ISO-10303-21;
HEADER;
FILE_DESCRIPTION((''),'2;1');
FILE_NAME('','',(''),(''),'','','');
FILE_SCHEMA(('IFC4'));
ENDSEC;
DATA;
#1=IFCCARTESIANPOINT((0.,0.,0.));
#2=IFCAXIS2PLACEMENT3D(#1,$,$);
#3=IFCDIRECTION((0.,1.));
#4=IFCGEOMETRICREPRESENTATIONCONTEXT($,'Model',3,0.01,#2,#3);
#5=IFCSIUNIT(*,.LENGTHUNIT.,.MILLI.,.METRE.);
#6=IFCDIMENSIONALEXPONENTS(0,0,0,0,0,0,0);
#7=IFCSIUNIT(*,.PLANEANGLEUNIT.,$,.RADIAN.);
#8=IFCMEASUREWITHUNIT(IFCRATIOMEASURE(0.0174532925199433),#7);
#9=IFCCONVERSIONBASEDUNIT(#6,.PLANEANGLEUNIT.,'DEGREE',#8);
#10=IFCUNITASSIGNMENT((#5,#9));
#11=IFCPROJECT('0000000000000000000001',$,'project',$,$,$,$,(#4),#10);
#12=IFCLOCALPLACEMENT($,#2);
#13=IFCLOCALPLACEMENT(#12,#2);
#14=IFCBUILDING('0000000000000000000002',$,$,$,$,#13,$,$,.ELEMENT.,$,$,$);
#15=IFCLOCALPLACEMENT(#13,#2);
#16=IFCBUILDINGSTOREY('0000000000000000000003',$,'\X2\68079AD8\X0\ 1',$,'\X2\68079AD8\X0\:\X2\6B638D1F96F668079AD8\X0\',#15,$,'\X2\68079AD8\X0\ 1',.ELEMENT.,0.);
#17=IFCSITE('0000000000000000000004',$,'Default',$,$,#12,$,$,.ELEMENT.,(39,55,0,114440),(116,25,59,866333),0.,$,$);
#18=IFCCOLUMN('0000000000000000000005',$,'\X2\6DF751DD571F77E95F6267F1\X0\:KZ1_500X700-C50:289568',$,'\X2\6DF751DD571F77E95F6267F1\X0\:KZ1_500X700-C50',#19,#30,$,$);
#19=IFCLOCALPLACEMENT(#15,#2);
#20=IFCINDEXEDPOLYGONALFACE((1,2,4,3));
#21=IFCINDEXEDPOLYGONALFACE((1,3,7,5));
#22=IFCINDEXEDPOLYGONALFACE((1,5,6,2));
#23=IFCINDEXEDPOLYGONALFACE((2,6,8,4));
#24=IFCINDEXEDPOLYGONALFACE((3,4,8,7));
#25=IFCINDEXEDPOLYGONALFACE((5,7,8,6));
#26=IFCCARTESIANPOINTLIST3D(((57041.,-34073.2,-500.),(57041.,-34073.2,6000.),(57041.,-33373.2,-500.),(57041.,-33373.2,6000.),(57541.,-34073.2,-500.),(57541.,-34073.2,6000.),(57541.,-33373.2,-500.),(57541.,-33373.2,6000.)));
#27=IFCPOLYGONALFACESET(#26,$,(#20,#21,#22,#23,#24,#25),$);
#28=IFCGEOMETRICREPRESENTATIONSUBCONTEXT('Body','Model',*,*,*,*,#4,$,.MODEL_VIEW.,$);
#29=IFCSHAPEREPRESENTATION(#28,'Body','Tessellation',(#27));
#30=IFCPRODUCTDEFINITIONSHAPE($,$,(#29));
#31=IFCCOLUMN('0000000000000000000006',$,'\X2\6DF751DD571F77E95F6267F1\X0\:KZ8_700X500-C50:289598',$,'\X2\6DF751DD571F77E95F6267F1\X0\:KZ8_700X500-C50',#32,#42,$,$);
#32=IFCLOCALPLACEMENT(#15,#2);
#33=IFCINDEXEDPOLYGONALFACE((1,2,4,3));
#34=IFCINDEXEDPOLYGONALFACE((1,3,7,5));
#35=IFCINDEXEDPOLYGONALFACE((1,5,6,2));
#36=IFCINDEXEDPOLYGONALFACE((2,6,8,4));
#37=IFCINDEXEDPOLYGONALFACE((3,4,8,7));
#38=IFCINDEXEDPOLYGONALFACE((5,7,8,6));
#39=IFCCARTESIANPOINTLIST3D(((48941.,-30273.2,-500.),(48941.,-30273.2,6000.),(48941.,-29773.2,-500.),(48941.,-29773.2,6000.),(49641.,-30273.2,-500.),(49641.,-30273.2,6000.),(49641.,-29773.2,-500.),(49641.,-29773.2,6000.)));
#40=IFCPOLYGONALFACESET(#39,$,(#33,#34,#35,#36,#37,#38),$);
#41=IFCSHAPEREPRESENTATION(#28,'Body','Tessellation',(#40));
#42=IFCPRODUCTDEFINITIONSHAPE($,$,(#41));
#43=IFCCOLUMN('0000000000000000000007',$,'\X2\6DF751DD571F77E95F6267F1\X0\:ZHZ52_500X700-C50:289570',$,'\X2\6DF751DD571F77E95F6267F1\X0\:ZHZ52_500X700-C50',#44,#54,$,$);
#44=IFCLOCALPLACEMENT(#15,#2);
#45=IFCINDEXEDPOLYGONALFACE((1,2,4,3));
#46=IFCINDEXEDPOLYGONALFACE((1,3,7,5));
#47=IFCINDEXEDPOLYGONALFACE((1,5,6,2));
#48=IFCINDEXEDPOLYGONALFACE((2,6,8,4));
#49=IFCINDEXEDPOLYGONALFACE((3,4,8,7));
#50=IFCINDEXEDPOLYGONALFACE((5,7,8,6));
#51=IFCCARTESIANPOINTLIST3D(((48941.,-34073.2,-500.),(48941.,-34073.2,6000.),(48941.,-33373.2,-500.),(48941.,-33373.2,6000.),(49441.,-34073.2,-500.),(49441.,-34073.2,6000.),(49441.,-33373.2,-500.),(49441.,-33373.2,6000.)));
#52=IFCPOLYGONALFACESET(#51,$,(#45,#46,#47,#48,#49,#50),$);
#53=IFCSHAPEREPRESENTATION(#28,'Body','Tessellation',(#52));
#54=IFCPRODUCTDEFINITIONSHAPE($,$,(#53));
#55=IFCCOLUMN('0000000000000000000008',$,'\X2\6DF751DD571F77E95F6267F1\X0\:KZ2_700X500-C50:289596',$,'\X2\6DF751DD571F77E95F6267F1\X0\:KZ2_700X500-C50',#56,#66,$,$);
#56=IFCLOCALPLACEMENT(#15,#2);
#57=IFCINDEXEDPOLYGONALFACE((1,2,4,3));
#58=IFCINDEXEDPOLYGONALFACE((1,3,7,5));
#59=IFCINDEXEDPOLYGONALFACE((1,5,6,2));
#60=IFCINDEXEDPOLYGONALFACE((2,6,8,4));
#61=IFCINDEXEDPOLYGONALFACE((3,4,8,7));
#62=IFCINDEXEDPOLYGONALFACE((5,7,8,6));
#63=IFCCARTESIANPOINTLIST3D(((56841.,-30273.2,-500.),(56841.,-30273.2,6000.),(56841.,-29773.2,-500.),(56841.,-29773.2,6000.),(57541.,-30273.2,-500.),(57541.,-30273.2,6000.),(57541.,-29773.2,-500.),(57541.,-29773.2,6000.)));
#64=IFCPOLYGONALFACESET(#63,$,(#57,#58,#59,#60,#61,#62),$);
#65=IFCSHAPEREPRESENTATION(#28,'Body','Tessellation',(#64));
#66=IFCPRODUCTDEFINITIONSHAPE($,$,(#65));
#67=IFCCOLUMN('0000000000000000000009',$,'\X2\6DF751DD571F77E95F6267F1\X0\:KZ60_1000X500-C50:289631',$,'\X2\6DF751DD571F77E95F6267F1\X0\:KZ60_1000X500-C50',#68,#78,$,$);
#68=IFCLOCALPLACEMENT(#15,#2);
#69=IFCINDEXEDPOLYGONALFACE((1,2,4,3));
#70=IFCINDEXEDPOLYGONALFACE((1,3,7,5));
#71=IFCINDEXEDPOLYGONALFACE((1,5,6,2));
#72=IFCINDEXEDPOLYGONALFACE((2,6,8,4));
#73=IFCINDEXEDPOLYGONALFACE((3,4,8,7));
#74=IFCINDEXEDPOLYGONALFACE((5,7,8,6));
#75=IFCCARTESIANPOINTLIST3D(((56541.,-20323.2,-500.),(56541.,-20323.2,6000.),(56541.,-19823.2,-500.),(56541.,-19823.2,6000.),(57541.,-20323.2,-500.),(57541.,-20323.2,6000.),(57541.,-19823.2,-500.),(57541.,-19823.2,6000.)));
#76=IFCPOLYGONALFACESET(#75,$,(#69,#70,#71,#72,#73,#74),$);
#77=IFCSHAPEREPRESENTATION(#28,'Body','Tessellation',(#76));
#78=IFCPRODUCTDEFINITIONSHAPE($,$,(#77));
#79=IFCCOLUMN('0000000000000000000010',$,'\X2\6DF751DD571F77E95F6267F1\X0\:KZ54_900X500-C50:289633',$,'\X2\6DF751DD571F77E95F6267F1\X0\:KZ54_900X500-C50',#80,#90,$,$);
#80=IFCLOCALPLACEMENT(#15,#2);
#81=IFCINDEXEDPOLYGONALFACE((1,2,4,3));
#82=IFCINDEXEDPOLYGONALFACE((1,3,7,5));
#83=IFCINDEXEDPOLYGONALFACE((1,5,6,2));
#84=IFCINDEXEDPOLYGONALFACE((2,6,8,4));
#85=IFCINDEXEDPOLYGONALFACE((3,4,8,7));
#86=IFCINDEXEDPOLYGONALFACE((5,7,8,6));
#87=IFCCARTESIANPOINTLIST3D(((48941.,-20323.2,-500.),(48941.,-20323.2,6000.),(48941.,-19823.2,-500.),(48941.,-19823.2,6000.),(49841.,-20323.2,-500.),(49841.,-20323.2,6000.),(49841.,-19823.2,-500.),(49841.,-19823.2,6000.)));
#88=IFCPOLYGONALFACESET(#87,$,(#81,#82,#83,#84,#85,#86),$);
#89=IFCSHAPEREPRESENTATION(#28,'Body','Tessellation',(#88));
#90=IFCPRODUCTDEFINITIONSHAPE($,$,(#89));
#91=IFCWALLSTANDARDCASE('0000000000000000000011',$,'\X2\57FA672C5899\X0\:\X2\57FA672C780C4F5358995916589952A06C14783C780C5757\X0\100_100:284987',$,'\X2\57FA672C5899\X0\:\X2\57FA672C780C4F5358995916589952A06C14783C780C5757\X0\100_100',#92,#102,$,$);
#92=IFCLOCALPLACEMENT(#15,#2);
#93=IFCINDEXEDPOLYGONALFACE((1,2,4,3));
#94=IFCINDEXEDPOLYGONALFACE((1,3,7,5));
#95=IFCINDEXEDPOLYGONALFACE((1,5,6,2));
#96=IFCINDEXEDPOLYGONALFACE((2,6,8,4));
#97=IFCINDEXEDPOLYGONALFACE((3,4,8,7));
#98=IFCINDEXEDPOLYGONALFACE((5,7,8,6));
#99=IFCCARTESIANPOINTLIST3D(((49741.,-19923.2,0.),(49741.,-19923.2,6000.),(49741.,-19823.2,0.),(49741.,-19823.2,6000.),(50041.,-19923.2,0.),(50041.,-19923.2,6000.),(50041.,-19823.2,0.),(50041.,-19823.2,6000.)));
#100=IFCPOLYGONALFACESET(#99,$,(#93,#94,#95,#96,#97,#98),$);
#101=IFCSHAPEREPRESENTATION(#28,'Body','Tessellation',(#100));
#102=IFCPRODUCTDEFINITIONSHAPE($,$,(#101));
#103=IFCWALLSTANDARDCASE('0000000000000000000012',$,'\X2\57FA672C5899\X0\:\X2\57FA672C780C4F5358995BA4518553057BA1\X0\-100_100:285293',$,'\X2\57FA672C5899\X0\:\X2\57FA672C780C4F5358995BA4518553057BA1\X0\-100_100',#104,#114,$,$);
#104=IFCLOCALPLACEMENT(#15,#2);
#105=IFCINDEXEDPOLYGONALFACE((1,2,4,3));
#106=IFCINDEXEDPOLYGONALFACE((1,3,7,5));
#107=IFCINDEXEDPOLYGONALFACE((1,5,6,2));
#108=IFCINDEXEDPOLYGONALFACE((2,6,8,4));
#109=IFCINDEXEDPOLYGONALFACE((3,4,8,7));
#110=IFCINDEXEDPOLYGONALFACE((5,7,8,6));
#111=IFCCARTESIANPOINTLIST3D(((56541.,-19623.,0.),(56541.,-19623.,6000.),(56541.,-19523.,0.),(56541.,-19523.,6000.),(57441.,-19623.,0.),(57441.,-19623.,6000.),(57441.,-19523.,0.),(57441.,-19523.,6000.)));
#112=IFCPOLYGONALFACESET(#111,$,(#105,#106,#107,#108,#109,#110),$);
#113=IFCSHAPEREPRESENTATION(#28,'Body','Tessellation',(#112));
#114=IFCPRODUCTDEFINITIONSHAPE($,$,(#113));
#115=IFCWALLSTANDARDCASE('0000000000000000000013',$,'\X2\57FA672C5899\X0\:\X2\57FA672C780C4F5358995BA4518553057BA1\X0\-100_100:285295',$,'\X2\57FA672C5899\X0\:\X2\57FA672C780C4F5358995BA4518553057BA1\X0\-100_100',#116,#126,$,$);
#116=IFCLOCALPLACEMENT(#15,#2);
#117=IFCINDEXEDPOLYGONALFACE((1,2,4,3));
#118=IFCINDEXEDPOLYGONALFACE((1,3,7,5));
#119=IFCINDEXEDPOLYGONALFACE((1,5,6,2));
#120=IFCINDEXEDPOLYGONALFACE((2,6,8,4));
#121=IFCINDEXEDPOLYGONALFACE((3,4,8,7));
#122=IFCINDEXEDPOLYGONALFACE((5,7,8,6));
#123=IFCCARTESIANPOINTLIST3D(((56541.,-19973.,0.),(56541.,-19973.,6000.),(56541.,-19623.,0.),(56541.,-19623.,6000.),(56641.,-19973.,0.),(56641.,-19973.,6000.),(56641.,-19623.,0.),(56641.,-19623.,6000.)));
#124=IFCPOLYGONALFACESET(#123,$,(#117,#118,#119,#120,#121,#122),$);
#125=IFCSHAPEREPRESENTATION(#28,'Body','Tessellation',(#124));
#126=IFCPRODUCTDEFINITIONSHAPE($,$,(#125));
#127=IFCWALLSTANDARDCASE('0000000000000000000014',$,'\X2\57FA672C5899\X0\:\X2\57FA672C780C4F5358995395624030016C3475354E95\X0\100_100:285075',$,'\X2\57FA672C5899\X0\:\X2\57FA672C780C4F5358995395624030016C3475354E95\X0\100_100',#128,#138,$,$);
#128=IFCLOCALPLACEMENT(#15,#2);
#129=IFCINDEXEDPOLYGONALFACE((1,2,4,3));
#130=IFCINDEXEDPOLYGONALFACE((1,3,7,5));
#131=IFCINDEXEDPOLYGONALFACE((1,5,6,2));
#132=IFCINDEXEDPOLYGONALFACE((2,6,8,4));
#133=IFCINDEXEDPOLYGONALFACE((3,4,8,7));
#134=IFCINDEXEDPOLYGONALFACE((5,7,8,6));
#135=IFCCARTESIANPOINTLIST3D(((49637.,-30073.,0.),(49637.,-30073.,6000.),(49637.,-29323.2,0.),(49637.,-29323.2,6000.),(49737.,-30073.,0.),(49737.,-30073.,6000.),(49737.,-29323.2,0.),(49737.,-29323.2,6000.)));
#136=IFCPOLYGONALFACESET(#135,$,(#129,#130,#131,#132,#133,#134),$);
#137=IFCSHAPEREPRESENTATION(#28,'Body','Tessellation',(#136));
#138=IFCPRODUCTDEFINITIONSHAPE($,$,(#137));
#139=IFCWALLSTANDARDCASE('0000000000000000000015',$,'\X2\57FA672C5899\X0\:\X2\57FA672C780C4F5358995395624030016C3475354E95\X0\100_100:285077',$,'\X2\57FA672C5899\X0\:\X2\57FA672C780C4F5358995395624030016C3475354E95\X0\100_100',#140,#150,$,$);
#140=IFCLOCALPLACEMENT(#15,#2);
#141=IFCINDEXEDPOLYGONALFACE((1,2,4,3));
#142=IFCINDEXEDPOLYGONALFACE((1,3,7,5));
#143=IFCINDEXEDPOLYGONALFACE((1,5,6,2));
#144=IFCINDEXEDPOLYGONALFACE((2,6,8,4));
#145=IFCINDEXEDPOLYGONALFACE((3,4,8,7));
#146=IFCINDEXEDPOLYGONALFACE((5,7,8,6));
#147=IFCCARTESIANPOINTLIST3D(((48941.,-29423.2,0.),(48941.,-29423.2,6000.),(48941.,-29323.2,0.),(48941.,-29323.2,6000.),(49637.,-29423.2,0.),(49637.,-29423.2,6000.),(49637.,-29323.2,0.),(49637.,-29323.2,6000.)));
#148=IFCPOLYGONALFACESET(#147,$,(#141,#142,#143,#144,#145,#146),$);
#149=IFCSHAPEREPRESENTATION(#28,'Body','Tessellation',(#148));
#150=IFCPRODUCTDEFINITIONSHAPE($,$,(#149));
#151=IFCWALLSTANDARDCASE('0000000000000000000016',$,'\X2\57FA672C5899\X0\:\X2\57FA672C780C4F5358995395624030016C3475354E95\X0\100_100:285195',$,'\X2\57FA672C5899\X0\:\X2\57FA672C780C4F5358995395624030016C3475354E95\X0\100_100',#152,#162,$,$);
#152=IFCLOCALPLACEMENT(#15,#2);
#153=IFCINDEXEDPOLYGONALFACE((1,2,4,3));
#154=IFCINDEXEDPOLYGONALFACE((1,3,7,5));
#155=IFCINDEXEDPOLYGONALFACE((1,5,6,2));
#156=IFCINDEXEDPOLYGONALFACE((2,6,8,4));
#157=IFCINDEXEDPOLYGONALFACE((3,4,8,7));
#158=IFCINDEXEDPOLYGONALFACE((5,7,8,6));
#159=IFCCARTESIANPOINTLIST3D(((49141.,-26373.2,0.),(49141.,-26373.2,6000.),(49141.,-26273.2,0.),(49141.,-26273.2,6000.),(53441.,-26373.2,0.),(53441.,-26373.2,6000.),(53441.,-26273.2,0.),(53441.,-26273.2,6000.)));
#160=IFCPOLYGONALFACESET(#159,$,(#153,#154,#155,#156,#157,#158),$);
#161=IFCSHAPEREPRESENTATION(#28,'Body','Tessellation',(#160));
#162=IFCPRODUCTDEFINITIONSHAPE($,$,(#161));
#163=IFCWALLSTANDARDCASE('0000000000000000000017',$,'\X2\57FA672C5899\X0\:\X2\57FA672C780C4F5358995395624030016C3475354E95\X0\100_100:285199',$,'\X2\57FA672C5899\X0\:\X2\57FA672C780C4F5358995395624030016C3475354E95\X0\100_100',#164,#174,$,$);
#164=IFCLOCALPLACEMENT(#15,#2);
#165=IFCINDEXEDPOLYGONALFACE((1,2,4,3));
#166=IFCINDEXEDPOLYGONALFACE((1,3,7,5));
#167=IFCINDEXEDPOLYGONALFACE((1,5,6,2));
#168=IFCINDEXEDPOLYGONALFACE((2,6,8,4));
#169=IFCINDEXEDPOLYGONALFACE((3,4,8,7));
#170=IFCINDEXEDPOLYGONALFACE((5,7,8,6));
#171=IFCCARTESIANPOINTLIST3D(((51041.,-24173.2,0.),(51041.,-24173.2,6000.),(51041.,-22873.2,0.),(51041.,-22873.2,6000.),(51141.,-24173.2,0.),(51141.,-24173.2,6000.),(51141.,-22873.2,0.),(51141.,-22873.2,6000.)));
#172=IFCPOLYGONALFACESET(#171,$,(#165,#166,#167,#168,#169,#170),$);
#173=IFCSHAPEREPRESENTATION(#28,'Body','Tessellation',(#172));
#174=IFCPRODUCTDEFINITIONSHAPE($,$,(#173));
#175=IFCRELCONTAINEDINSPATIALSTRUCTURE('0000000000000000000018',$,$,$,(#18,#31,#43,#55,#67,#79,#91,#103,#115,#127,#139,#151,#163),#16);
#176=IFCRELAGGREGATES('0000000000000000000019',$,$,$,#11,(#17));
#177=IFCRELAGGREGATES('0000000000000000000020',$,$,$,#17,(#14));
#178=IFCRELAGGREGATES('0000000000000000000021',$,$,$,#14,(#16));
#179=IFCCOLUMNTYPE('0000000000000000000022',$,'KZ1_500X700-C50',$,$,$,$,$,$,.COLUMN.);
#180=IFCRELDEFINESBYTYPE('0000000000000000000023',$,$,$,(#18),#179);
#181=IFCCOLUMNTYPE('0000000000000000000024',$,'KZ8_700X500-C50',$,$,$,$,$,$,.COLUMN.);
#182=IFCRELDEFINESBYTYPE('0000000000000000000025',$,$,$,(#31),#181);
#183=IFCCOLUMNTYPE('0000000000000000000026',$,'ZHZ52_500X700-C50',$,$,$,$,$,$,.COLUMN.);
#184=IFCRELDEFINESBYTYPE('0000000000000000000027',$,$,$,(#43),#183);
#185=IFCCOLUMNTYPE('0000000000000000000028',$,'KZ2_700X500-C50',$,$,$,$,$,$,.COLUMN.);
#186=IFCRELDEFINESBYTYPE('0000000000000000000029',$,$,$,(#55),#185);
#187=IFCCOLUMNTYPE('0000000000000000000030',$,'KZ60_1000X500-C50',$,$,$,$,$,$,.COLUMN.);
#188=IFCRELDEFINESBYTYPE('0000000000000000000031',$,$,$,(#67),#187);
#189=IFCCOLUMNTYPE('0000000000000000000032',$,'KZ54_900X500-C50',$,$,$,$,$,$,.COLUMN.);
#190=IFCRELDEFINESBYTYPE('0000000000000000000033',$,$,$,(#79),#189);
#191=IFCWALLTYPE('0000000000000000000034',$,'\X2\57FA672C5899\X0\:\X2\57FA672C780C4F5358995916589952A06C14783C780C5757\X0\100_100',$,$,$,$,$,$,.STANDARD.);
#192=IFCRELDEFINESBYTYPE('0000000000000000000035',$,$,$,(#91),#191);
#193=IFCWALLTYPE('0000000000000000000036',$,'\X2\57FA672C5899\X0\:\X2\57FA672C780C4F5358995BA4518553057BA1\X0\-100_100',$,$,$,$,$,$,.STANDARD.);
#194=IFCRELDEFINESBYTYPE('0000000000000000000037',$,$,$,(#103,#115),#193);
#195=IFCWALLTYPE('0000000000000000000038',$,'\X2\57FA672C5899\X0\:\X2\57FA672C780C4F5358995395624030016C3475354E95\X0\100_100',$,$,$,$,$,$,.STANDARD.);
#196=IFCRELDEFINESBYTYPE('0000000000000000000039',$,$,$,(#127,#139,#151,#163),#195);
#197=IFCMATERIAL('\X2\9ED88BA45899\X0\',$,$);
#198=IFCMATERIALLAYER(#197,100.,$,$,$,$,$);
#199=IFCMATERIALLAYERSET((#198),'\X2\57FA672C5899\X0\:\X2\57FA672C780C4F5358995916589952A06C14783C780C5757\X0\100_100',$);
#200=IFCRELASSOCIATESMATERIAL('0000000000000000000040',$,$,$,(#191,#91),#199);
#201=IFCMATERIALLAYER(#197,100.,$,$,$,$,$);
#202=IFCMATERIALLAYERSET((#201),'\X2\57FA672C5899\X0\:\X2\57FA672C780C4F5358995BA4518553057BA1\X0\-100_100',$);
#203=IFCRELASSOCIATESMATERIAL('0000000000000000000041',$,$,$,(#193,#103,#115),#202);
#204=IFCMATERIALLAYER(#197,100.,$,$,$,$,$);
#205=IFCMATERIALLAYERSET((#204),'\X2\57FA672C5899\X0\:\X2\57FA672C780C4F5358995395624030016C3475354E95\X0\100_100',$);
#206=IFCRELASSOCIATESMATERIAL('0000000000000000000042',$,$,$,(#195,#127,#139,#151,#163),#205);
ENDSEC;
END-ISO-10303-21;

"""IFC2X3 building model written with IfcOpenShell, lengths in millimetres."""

from ifc_helpers import new_model, entity, si_unit, converted_unit, direction, frame, frame_2d, origin, origin_2d_with_axis, place, context, subcontext, project, spatial, rectangle, extrude, source, transform, mapped, material, layer, layer_set, layer_usage, type_object, type_shapes, element, save


model = new_model("IFC2X3")

# Units and contexts
model_context = context("Model", 3, precision=0.01, world=origin(), true_north=direction((0.0, 1.0)))
body_context = subcontext(model_context, "Body", "Model", "MODEL_VIEW")
ifc_project = project(units=[si_unit("LENGTHUNIT", "METRE", prefix="MILLI"), converted_unit("PLANEANGLEUNIT", "DEGREE", entity("IfcRatioMeasure", 0.0174532925199433), si_unit("PLANEANGLEUNIT", "RADIAN"), dimensions=[0, 0, 0, 0, 0, 0, 0])], contexts=[model_context])

# Site, building, storey
site_placement = place(None, origin())
site = spatial("IfcSite", under=ifc_project, at=site_placement, Name="Default", CompositionType="ELEMENT", RefLatitude=(39, 55, 0, 114440), RefLongitude=(116, 25, 59, 866333), RefElevation=0.0)
building_placement = place(site_placement, origin())
building = spatial("IfcBuilding", under=site, at=building_placement, CompositionType="ELEMENT")
storey_placement = place(building_placement, origin())
storey = spatial("IfcBuildingStorey", under=building, at=storey_placement, Name="标高 1", ObjectType="标高:正负零标高", LongName="标高 1", CompositionType="ELEMENT", Elevation=0.0)

# Columns
column_type_1 = type_object("IfcColumnType", Name="KZ1_500X700-C50", PredefinedType="COLUMN")
shared_shape_1 = source(origin(), body_context, "Body", "SweptSolid", [
    extrude(rectangle(XDim=700.0, YDim=500.0, at=origin_2d_with_axis()), frame((0.0, 0.0, -500.0), z_axis=(0.0, 0.0, 1.0), x_axis=(0.0, -1.0, 0.0)), (0.0, 0.0, 1.0), 6500.0),
])
type_shapes(column_type_1, [shared_shape_1])
column_1_placement = place(building_placement, frame((57291.0, -33723.2, 0.0)))
element("IfcColumn", 1, at=column_1_placement, inside=storey, type_object=column_type_1, Name="混凝土矩形柱:KZ1_500X700-C50:289568", ObjectType="混凝土矩形柱:KZ1_500X700-C50", context=body_context, shape_type="MappedRepresentation", body=[
    mapped(shared_shape_1, transform((0.0, 0.0, 0.0), scale=1.0)),
])
column_type_2 = type_object("IfcColumnType", Name="KZ8_700X500-C50", PredefinedType="COLUMN")
shared_shape_2 = source(origin(), body_context, "Body", "SweptSolid", [
    extrude(rectangle(XDim=500.0, YDim=700.0, at=origin_2d_with_axis()), frame((0.0, 0.0, -500.0), z_axis=(0.0, 0.0, 1.0), x_axis=(0.0, -1.0, 0.0)), (0.0, 0.0, 1.0), 6500.0),
])
type_shapes(column_type_2, [shared_shape_2])
column_2_placement = place(building_placement, frame((49291.0, -30023.2, 0.0)))
element("IfcColumn", 2, at=column_2_placement, inside=storey, type_object=column_type_2, Name="混凝土矩形柱:KZ8_700X500-C50:289598", ObjectType="混凝土矩形柱:KZ8_700X500-C50", context=body_context, shape_type="MappedRepresentation", body=[
    mapped(shared_shape_2, transform((0.0, 0.0, 0.0), scale=1.0)),
])
column_type_3 = type_object("IfcColumnType", Name="ZHZ52_500X700-C50", PredefinedType="COLUMN")
shared_shape_3 = source(origin(), body_context, "Body", "SweptSolid", [
    extrude(rectangle(XDim=700.0, YDim=500.0, at=origin_2d_with_axis()), frame((0.0, 0.0, -500.0), z_axis=(0.0, 0.0, 1.0), x_axis=(0.0, -1.0, 0.0)), (0.0, 0.0, 1.0), 6500.0),
])
type_shapes(column_type_3, [shared_shape_3])
column_3_placement = place(building_placement, frame((49191.0, -33723.2, 0.0)))
element("IfcColumn", 3, at=column_3_placement, inside=storey, type_object=column_type_3, Name="混凝土矩形柱:ZHZ52_500X700-C50:289570", ObjectType="混凝土矩形柱:ZHZ52_500X700-C50", context=body_context, shape_type="MappedRepresentation", body=[
    mapped(shared_shape_3, transform((0.0, 0.0, 0.0), scale=1.0)),
])
column_type_4 = type_object("IfcColumnType", Name="KZ2_700X500-C50", PredefinedType="COLUMN")
shared_shape_4 = source(origin(), body_context, "Body", "SweptSolid", [
    extrude(rectangle(XDim=500.0, YDim=700.0, at=origin_2d_with_axis()), frame((0.0, 0.0, -500.0), z_axis=(0.0, 0.0, 1.0), x_axis=(0.0, -1.0, 0.0)), (0.0, 0.0, 1.0), 6500.0),
])
type_shapes(column_type_4, [shared_shape_4])
column_4_placement = place(building_placement, frame((57191.0, -30023.2, 0.0)))
element("IfcColumn", 4, at=column_4_placement, inside=storey, type_object=column_type_4, Name="混凝土矩形柱:KZ2_700X500-C50:289596", ObjectType="混凝土矩形柱:KZ2_700X500-C50", context=body_context, shape_type="MappedRepresentation", body=[
    mapped(shared_shape_4, transform((0.0, 0.0, 0.0), scale=1.0)),
])
column_type_5 = type_object("IfcColumnType", Name="KZ60_1000X500-C50", PredefinedType="COLUMN")
shared_shape_5 = source(origin(), body_context, "Body", "SweptSolid", [
    extrude(rectangle(XDim=500.0, YDim=1000.0, at=origin_2d_with_axis()), frame((0.0, 0.0, -500.0), z_axis=(0.0, 0.0, 1.0), x_axis=(0.0, -1.0, 0.0)), (0.0, 0.0, 1.0), 6500.0),
])
type_shapes(column_type_5, [shared_shape_5])
column_5_placement = place(building_placement, frame((57041.0, -20073.2, 0.0)))
element("IfcColumn", 5, at=column_5_placement, inside=storey, type_object=column_type_5, Name="混凝土矩形柱:KZ60_1000X500-C50:289631", ObjectType="混凝土矩形柱:KZ60_1000X500-C50", context=body_context, shape_type="MappedRepresentation", body=[
    mapped(shared_shape_5, transform((0.0, 0.0, 0.0), scale=1.0)),
])
column_type_6 = type_object("IfcColumnType", Name="KZ54_900X500-C50", PredefinedType="COLUMN")
shared_shape_6 = source(origin(), body_context, "Body", "SweptSolid", [
    extrude(rectangle(XDim=500.0, YDim=900.0, at=origin_2d_with_axis()), frame((0.0, 0.0, -500.0), z_axis=(0.0, 0.0, 1.0), x_axis=(0.0, -1.0, 0.0)), (0.0, 0.0, 1.0), 6500.0),
])
type_shapes(column_type_6, [shared_shape_6])
column_6_placement = place(building_placement, frame((49391.0, -20073.2, 0.0)))
element("IfcColumn", 6, at=column_6_placement, inside=storey, type_object=column_type_6, Name="混凝土矩形柱:KZ54_900X500-C50:289633", ObjectType="混凝土矩形柱:KZ54_900X500-C50", context=body_context, shape_type="MappedRepresentation", body=[
    mapped(shared_shape_6, transform((0.0, 0.0, 0.0), scale=1.0)),
])

# Walls
ifc_material = material(Name="默认墙")
ifc_layer_1 = layer(ifc_material, 100.0)
ifc_layer_set_1 = layer_set([ifc_layer_1], Name="基本墙:基本砌体墙外墙加气砼砌块100_100")
ifc_layer_usage_1 = layer_usage(ifc_layer_set_1, "AXIS2", "NEGATIVE", 50.0)
wall_type_1 = type_object("IfcWallType", Name="基本墙:基本砌体墙外墙加气砼砌块100_100", PredefinedType="STANDARD", material=ifc_layer_set_1)
wall_1_placement = place(building_placement, frame((49741.0, -19873.2, 0.0)))
element("IfcWallStandardCase", 7, at=wall_1_placement, inside=storey, type_object=wall_type_1, material=ifc_layer_usage_1, Name="基本墙:基本砌体墙外墙加气砼砌块100_100:284987", ObjectType="基本墙:基本砌体墙外墙加气砼砌块100_100", context=body_context, shape_type="SweptSolid", body=[
    extrude(rectangle(XDim=300.0, YDim=100.0, at=frame_2d((150.0, 0.0), x_axis=(-1.0, 0.0))), origin(), (0.0, 0.0, 1.0), 6000.0),
])
ifc_layer_2 = layer(ifc_material, 100.0)
ifc_layer_set_2 = layer_set([ifc_layer_2], Name="基本墙:基本砌体墙室内包管-100_100")
ifc_layer_usage_2 = layer_usage(ifc_layer_set_2, "AXIS2", "NEGATIVE", 50.0)
wall_type_2 = type_object("IfcWallType", Name="基本墙:基本砌体墙室内包管-100_100", PredefinedType="STANDARD", material=ifc_layer_set_2)
wall_2_placement = place(building_placement, frame((57441.0, -19573.0, 0.0), z_axis=(0.0, 0.0, 1.0), x_axis=(-1.0, 0.0, 0.0)))
element("IfcWallStandardCase", 8, at=wall_2_placement, inside=storey, type_object=wall_type_2, material=ifc_layer_usage_2, Name="基本墙:基本砌体墙室内包管-100_100:285293", ObjectType="基本墙:基本砌体墙室内包管-100_100", context=body_context, shape_type="SweptSolid", body=[
    extrude(rectangle(XDim=900.0, YDim=100.0, at=frame_2d((450.0, 0.0), x_axis=(-1.0, 0.0))), origin(), (0.0, 0.0, 1.0), 6000.0),
])
ifc_layer_usage_3 = layer_usage(ifc_layer_set_2, "AXIS2", "NEGATIVE", 50.0)
wall_3_placement = place(building_placement, frame((56591.0, -19623.0, 0.0), z_axis=(0.0, 0.0, 1.0), x_axis=(0.0, -1.0, 0.0)))
element("IfcWallStandardCase", 9, at=wall_3_placement, inside=storey, type_object=wall_type_2, material=ifc_layer_usage_3, Name="基本墙:基本砌体墙室内包管-100_100:285295", ObjectType="基本墙:基本砌体墙室内包管-100_100", context=body_context, shape_type="SweptSolid", body=[
    extrude(rectangle(XDim=350.0, YDim=100.0, at=frame_2d((175.0, 0.0), x_axis=(-1.0, 0.0))), origin(), (0.0, 0.0, 1.0), 6000.0),
])
ifc_layer_3 = layer(ifc_material, 100.0)
ifc_layer_set_3 = layer_set([ifc_layer_3], Name="基本墙:基本砌体墙厕所、水电井100_100")
ifc_layer_usage_4 = layer_usage(ifc_layer_set_3, "AXIS2", "NEGATIVE", 50.0)
wall_type_3 = type_object("IfcWallType", Name="基本墙:基本砌体墙厕所、水电井100_100", PredefinedType="STANDARD", material=ifc_layer_set_3)
wall_4_placement = place(building_placement, frame((49687.0, -29323.2, 0.0), z_axis=(0.0, 0.0, 1.0), x_axis=(0.0, -1.0, 0.0)))
element("IfcWallStandardCase", 10, at=wall_4_placement, inside=storey, type_object=wall_type_3, material=ifc_layer_usage_4, Name="基本墙:基本砌体墙厕所、水电井100_100:285075", ObjectType="基本墙:基本砌体墙厕所、水电井100_100", context=body_context, shape_type="SweptSolid", body=[
    extrude(rectangle(XDim=749.9, YDim=100.0, at=frame_2d((374.9, 0.0), x_axis=(-1.0, 0.0))), origin(), (0.0, 0.0, 1.0), 6000.0),
])
ifc_layer_usage_5 = layer_usage(ifc_layer_set_3, "AXIS2", "NEGATIVE", 50.0)
wall_5_placement = place(building_placement, frame((48941.0, -29373.2, 0.0)))
element("IfcWallStandardCase", 11, at=wall_5_placement, inside=storey, type_object=wall_type_3, material=ifc_layer_usage_5, Name="基本墙:基本砌体墙厕所、水电井100_100:285077", ObjectType="基本墙:基本砌体墙厕所、水电井100_100", context=body_context, shape_type="SweptSolid", body=[
    extrude(rectangle(XDim=696.0, YDim=100.0, at=frame_2d((348.0, 0.0), x_axis=(-1.0, 0.0))), origin(), (0.0, 0.0, 1.0), 6000.0),
])
ifc_layer_usage_6 = layer_usage(ifc_layer_set_3, "AXIS2", "NEGATIVE", 50.0)
wall_6_placement = place(building_placement, frame((49141.0, -26323.2, 0.0)))
element("IfcWallStandardCase", 12, at=wall_6_placement, inside=storey, type_object=wall_type_3, material=ifc_layer_usage_6, Name="基本墙:基本砌体墙厕所、水电井100_100:285195", ObjectType="基本墙:基本砌体墙厕所、水电井100_100", context=body_context, shape_type="SweptSolid", body=[
    extrude(rectangle(XDim=4300.0, YDim=100.0, at=frame_2d((2150.0, 0.0), x_axis=(-1.0, 0.0))), origin(), (0.0, 0.0, 1.0), 6000.0),
])
ifc_layer_usage_7 = layer_usage(ifc_layer_set_3, "AXIS2", "NEGATIVE", 50.0)
wall_7_placement = place(building_placement, frame((51091.0, -22873.2, 0.0), z_axis=(0.0, 0.0, 1.0), x_axis=(0.0, -1.0, 0.0)))
element("IfcWallStandardCase", 13, at=wall_7_placement, inside=storey, type_object=wall_type_3, material=ifc_layer_usage_7, Name="基本墙:基本砌体墙厕所、水电井100_100:285199", ObjectType="基本墙:基本砌体墙厕所、水电井100_100", context=body_context, shape_type="SweptSolid", body=[
    extrude(rectangle(XDim=1300.0, YDim=100.0, at=frame_2d((650.0, 0.0), x_axis=(-1.0, 0.0))), origin(), (0.0, 0.0, 1.0), 6000.0),
])

save(model, "model.ifc")
